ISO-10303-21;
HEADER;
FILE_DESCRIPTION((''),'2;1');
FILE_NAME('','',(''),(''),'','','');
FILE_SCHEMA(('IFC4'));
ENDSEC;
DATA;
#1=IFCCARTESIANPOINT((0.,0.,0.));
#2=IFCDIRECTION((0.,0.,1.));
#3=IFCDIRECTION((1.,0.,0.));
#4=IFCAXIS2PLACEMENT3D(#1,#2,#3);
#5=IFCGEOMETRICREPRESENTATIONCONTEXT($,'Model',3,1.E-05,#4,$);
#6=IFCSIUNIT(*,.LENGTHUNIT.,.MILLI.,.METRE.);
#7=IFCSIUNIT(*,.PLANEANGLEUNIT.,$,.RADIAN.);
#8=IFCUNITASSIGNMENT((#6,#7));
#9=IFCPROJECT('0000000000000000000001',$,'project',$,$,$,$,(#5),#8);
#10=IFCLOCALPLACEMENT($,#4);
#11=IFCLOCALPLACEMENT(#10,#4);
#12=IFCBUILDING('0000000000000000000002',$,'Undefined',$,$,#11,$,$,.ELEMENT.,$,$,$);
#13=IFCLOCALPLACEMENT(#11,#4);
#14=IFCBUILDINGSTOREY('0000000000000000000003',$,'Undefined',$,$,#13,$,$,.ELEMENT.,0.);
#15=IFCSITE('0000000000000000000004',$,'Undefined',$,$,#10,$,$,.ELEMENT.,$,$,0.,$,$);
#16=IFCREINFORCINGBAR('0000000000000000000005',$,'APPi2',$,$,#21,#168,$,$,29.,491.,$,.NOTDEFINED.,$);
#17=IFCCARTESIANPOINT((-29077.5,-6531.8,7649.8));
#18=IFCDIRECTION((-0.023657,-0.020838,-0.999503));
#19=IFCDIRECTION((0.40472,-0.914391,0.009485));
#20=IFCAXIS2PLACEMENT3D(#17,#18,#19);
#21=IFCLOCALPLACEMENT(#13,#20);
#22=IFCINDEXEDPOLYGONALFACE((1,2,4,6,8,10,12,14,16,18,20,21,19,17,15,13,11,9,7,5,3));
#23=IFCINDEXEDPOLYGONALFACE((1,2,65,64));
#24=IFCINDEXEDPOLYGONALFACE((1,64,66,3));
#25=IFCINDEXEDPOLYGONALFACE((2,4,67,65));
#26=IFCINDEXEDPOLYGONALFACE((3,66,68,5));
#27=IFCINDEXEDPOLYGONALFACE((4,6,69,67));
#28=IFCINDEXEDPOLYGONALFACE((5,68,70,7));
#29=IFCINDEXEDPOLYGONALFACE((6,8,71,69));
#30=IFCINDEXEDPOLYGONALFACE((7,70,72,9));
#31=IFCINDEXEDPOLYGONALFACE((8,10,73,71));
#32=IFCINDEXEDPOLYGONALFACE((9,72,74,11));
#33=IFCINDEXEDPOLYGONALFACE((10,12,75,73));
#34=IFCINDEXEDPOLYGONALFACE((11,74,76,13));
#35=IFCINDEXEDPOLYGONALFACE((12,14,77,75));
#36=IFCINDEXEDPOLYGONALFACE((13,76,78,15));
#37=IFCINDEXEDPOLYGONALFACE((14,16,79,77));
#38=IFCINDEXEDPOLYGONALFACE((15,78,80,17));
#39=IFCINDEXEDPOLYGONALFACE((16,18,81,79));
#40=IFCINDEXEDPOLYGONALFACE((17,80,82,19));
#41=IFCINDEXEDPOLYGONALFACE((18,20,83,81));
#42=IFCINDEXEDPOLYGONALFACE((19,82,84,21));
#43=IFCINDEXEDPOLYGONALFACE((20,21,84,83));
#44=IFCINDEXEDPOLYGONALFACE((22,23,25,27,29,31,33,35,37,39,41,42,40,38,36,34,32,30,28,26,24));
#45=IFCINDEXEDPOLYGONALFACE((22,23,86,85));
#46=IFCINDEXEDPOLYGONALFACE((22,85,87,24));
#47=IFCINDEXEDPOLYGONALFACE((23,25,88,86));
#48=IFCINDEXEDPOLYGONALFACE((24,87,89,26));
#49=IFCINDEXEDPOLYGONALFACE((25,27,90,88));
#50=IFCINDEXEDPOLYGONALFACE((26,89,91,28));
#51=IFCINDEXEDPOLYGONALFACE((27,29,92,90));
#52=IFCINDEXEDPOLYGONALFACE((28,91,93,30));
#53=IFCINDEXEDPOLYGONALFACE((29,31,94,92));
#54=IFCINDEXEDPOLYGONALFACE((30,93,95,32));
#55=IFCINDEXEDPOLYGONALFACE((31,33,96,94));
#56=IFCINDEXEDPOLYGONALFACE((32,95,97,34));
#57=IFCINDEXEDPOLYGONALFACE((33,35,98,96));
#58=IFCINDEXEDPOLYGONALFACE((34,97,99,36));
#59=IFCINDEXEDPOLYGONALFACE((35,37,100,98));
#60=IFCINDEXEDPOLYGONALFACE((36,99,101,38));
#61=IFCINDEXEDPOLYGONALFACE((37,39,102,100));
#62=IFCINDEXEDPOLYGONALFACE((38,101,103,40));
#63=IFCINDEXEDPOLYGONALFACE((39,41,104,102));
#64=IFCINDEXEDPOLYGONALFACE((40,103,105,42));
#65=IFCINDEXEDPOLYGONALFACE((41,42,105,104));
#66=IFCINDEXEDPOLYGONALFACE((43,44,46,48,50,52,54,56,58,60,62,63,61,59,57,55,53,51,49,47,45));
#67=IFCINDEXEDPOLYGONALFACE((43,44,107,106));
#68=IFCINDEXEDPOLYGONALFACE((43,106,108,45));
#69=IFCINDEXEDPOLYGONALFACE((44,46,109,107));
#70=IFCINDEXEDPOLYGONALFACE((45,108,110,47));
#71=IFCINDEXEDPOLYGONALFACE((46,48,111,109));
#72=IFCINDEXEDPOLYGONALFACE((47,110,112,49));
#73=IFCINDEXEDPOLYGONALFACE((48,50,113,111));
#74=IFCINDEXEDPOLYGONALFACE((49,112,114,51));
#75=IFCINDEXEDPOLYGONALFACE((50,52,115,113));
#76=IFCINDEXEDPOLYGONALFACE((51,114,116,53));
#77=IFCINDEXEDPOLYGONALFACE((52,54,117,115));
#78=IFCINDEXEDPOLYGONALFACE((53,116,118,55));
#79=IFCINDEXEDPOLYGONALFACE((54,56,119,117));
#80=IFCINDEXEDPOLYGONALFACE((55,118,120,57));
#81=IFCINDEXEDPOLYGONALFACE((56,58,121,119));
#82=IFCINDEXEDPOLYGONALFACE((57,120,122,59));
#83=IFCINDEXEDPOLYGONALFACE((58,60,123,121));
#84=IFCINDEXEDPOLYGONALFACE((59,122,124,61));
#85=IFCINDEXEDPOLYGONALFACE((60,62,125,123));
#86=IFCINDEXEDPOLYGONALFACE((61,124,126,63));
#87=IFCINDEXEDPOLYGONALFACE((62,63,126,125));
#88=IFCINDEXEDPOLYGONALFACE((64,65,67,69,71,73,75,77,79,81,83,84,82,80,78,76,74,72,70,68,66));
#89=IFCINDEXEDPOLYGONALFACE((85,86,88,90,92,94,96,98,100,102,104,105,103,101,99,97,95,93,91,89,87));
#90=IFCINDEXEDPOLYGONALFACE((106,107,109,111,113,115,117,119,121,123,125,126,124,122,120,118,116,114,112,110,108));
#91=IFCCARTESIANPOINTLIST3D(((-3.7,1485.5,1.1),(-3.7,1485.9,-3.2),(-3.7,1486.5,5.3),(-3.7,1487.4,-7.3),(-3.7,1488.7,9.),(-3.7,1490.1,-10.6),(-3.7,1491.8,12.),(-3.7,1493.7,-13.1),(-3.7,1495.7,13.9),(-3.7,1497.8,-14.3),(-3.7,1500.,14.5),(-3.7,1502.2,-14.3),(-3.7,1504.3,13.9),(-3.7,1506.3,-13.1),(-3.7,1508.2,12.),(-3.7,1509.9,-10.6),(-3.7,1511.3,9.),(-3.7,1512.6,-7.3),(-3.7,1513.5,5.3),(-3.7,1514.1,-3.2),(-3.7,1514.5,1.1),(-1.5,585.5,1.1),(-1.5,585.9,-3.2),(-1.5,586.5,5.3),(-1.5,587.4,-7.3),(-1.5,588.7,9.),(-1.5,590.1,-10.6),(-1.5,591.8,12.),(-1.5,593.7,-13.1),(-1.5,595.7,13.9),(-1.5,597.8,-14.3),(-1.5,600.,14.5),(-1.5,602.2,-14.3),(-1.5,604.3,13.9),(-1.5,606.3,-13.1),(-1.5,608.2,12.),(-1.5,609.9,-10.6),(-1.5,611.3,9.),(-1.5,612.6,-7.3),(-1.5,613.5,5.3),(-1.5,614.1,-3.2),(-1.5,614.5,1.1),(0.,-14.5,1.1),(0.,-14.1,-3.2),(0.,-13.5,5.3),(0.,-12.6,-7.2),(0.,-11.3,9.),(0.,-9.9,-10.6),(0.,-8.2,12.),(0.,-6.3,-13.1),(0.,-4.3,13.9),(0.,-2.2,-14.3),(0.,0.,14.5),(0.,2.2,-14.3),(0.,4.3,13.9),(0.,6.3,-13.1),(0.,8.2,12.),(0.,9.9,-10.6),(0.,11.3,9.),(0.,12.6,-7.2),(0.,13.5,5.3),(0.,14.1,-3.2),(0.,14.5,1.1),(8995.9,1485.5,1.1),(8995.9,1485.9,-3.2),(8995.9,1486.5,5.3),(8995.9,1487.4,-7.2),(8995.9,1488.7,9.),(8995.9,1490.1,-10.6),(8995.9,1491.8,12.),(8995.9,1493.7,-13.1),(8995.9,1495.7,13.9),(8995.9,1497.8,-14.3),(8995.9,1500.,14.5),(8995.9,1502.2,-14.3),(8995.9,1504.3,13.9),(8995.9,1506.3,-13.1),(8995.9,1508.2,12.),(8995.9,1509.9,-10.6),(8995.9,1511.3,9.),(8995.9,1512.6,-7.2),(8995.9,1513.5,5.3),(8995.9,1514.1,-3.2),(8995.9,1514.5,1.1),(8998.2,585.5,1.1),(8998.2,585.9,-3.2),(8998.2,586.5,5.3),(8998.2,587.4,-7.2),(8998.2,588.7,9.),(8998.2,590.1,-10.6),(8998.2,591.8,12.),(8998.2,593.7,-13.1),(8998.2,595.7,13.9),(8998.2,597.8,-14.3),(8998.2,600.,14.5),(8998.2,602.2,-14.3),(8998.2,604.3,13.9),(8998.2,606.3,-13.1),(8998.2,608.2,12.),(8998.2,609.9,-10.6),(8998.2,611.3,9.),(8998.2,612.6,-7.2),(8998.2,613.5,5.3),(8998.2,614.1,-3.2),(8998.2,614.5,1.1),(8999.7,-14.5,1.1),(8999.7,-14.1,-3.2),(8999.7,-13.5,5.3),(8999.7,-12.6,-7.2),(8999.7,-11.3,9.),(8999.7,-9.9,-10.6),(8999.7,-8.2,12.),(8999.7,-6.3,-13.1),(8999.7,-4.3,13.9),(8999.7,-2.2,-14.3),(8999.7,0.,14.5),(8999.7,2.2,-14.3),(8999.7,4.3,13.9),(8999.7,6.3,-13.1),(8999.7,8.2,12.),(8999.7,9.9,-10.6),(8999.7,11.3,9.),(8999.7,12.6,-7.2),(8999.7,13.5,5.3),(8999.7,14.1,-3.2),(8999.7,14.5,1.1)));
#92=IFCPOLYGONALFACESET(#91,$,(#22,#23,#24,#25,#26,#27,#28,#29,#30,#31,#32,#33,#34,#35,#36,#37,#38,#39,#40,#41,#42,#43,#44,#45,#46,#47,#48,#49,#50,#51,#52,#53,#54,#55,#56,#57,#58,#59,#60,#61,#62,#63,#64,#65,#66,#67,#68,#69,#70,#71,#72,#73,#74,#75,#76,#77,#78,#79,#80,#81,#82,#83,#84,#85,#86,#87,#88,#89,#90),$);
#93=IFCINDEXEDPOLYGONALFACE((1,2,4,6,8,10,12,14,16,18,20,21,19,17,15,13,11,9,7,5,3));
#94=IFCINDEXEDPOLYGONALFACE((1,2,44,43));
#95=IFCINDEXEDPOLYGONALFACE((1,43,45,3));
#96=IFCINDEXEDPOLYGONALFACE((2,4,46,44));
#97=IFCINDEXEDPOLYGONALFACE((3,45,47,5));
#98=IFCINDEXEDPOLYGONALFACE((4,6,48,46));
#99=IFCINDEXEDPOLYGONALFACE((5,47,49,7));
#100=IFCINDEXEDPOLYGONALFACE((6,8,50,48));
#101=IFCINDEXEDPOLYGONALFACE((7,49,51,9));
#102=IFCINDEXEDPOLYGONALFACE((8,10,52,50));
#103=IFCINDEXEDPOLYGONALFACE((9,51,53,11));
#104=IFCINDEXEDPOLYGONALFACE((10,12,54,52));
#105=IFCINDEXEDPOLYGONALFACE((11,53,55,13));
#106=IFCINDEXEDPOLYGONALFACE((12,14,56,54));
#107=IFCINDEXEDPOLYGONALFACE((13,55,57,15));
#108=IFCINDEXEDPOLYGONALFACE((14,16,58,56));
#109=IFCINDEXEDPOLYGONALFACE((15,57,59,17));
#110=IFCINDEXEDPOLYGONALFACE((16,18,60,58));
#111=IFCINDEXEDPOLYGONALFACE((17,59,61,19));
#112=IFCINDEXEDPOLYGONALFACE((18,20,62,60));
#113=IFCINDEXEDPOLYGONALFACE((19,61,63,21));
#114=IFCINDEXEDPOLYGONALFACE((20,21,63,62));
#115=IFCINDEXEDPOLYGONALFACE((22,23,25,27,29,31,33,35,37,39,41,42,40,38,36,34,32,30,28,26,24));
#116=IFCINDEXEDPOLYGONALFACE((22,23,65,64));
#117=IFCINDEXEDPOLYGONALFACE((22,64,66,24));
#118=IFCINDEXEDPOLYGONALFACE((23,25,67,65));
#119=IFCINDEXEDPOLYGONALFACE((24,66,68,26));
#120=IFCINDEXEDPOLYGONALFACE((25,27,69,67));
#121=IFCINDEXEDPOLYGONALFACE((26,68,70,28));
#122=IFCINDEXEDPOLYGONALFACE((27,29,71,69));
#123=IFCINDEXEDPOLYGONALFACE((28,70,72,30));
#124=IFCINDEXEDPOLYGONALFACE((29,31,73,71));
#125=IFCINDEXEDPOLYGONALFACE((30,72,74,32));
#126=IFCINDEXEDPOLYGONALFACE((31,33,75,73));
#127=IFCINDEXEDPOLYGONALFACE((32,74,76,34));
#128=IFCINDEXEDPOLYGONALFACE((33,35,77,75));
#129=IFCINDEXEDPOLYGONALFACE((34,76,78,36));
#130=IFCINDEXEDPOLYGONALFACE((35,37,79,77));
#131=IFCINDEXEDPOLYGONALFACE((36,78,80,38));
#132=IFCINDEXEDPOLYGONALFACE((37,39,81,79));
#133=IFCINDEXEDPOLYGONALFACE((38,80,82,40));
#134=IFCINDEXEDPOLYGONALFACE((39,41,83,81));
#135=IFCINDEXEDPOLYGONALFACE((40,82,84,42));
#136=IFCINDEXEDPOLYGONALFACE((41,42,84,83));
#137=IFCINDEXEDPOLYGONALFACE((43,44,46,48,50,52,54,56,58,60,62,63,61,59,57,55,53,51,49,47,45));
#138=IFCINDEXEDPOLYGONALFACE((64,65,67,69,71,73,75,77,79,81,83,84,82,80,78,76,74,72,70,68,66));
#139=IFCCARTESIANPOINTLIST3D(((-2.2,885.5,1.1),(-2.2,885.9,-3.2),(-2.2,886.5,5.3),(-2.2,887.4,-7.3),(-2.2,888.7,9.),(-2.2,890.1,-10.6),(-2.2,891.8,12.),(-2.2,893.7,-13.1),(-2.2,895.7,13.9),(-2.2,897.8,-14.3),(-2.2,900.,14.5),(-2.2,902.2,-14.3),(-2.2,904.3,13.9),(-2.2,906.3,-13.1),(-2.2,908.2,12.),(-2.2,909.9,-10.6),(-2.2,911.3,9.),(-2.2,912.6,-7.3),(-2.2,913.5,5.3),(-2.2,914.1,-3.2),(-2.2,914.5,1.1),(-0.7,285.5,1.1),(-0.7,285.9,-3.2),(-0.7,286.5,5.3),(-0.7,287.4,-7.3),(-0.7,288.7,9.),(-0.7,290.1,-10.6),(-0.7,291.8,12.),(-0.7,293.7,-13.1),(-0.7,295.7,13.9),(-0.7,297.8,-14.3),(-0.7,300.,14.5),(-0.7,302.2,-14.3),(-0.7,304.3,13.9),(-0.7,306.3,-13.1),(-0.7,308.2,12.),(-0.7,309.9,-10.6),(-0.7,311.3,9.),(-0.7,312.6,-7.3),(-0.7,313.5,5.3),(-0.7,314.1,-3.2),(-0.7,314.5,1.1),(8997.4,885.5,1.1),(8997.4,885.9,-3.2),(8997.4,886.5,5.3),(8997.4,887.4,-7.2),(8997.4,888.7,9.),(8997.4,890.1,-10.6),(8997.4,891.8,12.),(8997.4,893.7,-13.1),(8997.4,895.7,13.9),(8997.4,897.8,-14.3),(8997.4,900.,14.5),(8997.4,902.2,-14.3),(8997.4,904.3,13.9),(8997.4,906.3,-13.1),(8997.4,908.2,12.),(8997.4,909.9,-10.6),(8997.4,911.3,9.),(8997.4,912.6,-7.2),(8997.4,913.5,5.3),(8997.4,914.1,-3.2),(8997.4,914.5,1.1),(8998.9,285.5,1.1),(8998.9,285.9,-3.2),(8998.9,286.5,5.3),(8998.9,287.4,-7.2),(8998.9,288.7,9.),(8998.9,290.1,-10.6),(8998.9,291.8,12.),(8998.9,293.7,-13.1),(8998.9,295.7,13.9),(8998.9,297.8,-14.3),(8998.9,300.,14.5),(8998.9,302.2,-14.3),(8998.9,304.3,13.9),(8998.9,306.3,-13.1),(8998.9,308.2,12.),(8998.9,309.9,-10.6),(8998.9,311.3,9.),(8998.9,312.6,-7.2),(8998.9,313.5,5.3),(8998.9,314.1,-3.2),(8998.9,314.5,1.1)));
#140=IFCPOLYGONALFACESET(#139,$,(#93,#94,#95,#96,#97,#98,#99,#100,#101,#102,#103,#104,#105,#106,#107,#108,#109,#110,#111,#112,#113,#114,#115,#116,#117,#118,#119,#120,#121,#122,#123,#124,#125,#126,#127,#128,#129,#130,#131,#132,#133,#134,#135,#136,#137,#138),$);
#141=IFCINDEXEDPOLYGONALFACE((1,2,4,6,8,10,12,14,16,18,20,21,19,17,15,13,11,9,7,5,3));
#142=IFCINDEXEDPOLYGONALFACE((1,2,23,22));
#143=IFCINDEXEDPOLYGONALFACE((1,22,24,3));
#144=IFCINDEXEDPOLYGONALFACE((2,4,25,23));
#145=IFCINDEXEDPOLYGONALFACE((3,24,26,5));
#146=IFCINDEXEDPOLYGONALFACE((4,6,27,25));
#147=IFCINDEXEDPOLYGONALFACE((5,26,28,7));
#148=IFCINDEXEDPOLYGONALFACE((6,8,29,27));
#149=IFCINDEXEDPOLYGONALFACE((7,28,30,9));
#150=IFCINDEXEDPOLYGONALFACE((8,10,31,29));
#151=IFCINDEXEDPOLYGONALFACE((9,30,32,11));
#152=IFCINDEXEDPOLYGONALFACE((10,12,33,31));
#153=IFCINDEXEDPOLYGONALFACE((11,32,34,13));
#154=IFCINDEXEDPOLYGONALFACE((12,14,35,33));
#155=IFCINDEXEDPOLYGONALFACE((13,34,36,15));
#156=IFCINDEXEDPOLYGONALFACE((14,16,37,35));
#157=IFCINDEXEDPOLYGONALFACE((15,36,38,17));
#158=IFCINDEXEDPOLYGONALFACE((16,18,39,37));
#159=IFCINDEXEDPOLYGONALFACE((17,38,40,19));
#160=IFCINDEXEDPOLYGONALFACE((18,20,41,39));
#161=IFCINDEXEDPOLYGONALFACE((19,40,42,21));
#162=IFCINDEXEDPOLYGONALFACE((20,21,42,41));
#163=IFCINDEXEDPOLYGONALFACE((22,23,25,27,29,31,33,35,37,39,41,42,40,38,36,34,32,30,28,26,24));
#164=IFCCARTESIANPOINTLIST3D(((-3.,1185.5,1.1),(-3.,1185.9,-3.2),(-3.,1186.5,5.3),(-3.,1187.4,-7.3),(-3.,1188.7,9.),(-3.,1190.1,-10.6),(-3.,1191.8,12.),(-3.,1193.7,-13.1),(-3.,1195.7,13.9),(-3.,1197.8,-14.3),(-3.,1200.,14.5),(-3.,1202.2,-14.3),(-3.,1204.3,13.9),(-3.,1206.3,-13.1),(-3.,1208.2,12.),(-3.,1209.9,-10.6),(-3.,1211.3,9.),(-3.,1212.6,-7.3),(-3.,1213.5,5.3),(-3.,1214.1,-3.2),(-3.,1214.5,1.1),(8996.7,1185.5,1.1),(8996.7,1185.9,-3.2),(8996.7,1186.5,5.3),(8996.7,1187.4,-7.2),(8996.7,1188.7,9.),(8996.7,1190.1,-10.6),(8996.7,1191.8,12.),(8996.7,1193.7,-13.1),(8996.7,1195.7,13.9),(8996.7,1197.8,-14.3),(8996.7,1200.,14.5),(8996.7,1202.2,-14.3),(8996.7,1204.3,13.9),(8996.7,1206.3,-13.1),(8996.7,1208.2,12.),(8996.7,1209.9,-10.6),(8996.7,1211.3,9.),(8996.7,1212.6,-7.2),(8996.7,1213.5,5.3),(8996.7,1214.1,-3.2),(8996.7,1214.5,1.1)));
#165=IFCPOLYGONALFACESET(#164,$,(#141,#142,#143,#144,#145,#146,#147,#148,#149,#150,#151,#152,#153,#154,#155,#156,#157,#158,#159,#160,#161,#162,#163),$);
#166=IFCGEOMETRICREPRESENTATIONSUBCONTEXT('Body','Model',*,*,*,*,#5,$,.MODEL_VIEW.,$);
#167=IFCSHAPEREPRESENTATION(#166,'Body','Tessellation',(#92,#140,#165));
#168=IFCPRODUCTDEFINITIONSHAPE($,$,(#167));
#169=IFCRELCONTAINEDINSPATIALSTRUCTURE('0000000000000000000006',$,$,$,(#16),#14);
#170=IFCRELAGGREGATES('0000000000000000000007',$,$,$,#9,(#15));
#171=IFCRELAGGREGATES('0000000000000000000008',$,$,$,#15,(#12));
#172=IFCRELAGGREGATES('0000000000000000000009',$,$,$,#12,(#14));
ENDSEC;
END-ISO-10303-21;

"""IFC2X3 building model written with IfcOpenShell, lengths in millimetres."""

from ifc_helpers import new_model, entity, si_unit, frame, origin_with_axes, place, context, subcontext, project, spatial, source, transform, mapped, element, save


model = new_model("IFC2X3")

# Units and contexts
model_context = context("Model", 3, precision=1e-05, world=origin_with_axes())
body_context = subcontext(model_context, "Body", "Model", "MODEL_VIEW")
ifc_project = project(units=[si_unit("LENGTHUNIT", "METRE", prefix="MILLI"), si_unit("PLANEANGLEUNIT", "RADIAN")], contexts=[model_context])

# Site, building, storey
site_placement = place(None, origin_with_axes())
site = spatial("IfcSite", under=ifc_project, at=site_placement, Name="Undefined", CompositionType="ELEMENT", RefElevation=0.0)
building_placement = place(site_placement, origin_with_axes())
building = spatial("IfcBuilding", under=site, at=building_placement, Name="Undefined", CompositionType="ELEMENT")
storey_placement = place(building_placement, origin_with_axes())
storey = spatial("IfcBuildingStorey", under=building, at=storey_placement, Name="Undefined", CompositionType="ELEMENT", Elevation=0.0)

# Reinforcing bar
shared_shape_1 = source(origin_with_axes(), body_context, "Body", "AdvancedSweptSolid", [
    entity("IfcSweptDiskSolid", entity("IfcTrimmedCurve", entity("IfcLine", entity("IfcCartesianPoint", [0.0, 0.0, 0.0]), entity("IfcVector", entity("IfcDirection", [1.0, 0.0, 0.0]), 1.0)), [entity("IfcParameterValue", 0.0)], [entity("IfcParameterValue", 8999.680987)], True, "PARAMETER"), 14.5, None, 0.0, 8999.7),
])
shared_shape_2 = source(origin_with_axes(), body_context, "Body", "AdvancedSweptSolid", [
    entity("IfcSweptDiskSolid", entity("IfcTrimmedCurve", entity("IfcLine", entity("IfcCartesianPoint", [0.0, 0.0, 0.0]), entity("IfcVector", entity("IfcDirection", [1.0, 0.0, 0.0]), 1.0)), [entity("IfcParameterValue", 0.0)], [entity("IfcParameterValue", 8999.680987)], True, "PARAMETER"), 14.5, None, 0.0, 8999.7),
])
shared_shape_3 = source(origin_with_axes(), body_context, "Body", "AdvancedSweptSolid", [
    entity("IfcSweptDiskSolid", entity("IfcTrimmedCurve", entity("IfcLine", entity("IfcCartesianPoint", [0.0, 0.0, 0.0]), entity("IfcVector", entity("IfcDirection", [1.0, 0.0, 0.0]), 1.0)), [entity("IfcParameterValue", 0.0)], [entity("IfcParameterValue", 8999.680987)], True, "PARAMETER"), 14.5, None, 0.0, 8999.7),
])
shared_shape_4 = source(origin_with_axes(), body_context, "Body", "AdvancedSweptSolid", [
    entity("IfcSweptDiskSolid", entity("IfcTrimmedCurve", entity("IfcLine", entity("IfcCartesianPoint", [0.0, 0.0, 0.0]), entity("IfcVector", entity("IfcDirection", [1.0, 0.0, 0.0]), 1.0)), [entity("IfcParameterValue", 0.0)], [entity("IfcParameterValue", 8999.680987)], True, "PARAMETER"), 14.5, None, 0.0, 8999.7),
])
shared_shape_5 = source(origin_with_axes(), body_context, "Body", "AdvancedSweptSolid", [
    entity("IfcSweptDiskSolid", entity("IfcTrimmedCurve", entity("IfcLine", entity("IfcCartesianPoint", [0.0, 0.0, 0.0]), entity("IfcVector", entity("IfcDirection", [1.0, 0.0, 0.0]), 1.0)), [entity("IfcParameterValue", 0.0)], [entity("IfcParameterValue", 8999.680987)], True, "PARAMETER"), 14.5, None, 0.0, 8999.7),
])
shared_shape_6 = source(origin_with_axes(), body_context, "Body", "AdvancedSweptSolid", [
    entity("IfcSweptDiskSolid", entity("IfcTrimmedCurve", entity("IfcLine", entity("IfcCartesianPoint", [0.0, 0.0, 0.0]), entity("IfcVector", entity("IfcDirection", [1.0, 0.0, 0.0]), 1.0)), [entity("IfcParameterValue", 0.0)], [entity("IfcParameterValue", 8999.680987)], True, "PARAMETER"), 14.5, None, 0.0, 8999.7),
])
reinforcing_bar_1_placement = place(storey_placement, frame((-29077.5, -6531.8, 7649.8), z_axis=(-0.023657, -0.020838, -0.999503), x_axis=(0.40472, -0.914391, 0.009485)))
element("IfcReinforcingBar", 1, at=reinforcing_bar_1_placement, inside=storey, Name="APPi2", BarRole="NOTDEFINED", CrossSectionArea=491.0, NominalDiameter=29.0, context=body_context, shape_type="MappedRepresentation", body=[
    mapped(shared_shape_1, transform((0.0, 0.0, 0.0))),
    mapped(shared_shape_2, transform((-0.7, 300.0, 0.0))),
    mapped(shared_shape_3, transform((-1.5, 600.0, 0.0))),
    mapped(shared_shape_4, transform((-2.2, 900.0, 0.0))),
    mapped(shared_shape_5, transform((-3.0, 1200.0, 0.0))),
    mapped(shared_shape_6, transform((-3.7, 1500.0, 0.0))),
])

save(model, "model.ifc")
